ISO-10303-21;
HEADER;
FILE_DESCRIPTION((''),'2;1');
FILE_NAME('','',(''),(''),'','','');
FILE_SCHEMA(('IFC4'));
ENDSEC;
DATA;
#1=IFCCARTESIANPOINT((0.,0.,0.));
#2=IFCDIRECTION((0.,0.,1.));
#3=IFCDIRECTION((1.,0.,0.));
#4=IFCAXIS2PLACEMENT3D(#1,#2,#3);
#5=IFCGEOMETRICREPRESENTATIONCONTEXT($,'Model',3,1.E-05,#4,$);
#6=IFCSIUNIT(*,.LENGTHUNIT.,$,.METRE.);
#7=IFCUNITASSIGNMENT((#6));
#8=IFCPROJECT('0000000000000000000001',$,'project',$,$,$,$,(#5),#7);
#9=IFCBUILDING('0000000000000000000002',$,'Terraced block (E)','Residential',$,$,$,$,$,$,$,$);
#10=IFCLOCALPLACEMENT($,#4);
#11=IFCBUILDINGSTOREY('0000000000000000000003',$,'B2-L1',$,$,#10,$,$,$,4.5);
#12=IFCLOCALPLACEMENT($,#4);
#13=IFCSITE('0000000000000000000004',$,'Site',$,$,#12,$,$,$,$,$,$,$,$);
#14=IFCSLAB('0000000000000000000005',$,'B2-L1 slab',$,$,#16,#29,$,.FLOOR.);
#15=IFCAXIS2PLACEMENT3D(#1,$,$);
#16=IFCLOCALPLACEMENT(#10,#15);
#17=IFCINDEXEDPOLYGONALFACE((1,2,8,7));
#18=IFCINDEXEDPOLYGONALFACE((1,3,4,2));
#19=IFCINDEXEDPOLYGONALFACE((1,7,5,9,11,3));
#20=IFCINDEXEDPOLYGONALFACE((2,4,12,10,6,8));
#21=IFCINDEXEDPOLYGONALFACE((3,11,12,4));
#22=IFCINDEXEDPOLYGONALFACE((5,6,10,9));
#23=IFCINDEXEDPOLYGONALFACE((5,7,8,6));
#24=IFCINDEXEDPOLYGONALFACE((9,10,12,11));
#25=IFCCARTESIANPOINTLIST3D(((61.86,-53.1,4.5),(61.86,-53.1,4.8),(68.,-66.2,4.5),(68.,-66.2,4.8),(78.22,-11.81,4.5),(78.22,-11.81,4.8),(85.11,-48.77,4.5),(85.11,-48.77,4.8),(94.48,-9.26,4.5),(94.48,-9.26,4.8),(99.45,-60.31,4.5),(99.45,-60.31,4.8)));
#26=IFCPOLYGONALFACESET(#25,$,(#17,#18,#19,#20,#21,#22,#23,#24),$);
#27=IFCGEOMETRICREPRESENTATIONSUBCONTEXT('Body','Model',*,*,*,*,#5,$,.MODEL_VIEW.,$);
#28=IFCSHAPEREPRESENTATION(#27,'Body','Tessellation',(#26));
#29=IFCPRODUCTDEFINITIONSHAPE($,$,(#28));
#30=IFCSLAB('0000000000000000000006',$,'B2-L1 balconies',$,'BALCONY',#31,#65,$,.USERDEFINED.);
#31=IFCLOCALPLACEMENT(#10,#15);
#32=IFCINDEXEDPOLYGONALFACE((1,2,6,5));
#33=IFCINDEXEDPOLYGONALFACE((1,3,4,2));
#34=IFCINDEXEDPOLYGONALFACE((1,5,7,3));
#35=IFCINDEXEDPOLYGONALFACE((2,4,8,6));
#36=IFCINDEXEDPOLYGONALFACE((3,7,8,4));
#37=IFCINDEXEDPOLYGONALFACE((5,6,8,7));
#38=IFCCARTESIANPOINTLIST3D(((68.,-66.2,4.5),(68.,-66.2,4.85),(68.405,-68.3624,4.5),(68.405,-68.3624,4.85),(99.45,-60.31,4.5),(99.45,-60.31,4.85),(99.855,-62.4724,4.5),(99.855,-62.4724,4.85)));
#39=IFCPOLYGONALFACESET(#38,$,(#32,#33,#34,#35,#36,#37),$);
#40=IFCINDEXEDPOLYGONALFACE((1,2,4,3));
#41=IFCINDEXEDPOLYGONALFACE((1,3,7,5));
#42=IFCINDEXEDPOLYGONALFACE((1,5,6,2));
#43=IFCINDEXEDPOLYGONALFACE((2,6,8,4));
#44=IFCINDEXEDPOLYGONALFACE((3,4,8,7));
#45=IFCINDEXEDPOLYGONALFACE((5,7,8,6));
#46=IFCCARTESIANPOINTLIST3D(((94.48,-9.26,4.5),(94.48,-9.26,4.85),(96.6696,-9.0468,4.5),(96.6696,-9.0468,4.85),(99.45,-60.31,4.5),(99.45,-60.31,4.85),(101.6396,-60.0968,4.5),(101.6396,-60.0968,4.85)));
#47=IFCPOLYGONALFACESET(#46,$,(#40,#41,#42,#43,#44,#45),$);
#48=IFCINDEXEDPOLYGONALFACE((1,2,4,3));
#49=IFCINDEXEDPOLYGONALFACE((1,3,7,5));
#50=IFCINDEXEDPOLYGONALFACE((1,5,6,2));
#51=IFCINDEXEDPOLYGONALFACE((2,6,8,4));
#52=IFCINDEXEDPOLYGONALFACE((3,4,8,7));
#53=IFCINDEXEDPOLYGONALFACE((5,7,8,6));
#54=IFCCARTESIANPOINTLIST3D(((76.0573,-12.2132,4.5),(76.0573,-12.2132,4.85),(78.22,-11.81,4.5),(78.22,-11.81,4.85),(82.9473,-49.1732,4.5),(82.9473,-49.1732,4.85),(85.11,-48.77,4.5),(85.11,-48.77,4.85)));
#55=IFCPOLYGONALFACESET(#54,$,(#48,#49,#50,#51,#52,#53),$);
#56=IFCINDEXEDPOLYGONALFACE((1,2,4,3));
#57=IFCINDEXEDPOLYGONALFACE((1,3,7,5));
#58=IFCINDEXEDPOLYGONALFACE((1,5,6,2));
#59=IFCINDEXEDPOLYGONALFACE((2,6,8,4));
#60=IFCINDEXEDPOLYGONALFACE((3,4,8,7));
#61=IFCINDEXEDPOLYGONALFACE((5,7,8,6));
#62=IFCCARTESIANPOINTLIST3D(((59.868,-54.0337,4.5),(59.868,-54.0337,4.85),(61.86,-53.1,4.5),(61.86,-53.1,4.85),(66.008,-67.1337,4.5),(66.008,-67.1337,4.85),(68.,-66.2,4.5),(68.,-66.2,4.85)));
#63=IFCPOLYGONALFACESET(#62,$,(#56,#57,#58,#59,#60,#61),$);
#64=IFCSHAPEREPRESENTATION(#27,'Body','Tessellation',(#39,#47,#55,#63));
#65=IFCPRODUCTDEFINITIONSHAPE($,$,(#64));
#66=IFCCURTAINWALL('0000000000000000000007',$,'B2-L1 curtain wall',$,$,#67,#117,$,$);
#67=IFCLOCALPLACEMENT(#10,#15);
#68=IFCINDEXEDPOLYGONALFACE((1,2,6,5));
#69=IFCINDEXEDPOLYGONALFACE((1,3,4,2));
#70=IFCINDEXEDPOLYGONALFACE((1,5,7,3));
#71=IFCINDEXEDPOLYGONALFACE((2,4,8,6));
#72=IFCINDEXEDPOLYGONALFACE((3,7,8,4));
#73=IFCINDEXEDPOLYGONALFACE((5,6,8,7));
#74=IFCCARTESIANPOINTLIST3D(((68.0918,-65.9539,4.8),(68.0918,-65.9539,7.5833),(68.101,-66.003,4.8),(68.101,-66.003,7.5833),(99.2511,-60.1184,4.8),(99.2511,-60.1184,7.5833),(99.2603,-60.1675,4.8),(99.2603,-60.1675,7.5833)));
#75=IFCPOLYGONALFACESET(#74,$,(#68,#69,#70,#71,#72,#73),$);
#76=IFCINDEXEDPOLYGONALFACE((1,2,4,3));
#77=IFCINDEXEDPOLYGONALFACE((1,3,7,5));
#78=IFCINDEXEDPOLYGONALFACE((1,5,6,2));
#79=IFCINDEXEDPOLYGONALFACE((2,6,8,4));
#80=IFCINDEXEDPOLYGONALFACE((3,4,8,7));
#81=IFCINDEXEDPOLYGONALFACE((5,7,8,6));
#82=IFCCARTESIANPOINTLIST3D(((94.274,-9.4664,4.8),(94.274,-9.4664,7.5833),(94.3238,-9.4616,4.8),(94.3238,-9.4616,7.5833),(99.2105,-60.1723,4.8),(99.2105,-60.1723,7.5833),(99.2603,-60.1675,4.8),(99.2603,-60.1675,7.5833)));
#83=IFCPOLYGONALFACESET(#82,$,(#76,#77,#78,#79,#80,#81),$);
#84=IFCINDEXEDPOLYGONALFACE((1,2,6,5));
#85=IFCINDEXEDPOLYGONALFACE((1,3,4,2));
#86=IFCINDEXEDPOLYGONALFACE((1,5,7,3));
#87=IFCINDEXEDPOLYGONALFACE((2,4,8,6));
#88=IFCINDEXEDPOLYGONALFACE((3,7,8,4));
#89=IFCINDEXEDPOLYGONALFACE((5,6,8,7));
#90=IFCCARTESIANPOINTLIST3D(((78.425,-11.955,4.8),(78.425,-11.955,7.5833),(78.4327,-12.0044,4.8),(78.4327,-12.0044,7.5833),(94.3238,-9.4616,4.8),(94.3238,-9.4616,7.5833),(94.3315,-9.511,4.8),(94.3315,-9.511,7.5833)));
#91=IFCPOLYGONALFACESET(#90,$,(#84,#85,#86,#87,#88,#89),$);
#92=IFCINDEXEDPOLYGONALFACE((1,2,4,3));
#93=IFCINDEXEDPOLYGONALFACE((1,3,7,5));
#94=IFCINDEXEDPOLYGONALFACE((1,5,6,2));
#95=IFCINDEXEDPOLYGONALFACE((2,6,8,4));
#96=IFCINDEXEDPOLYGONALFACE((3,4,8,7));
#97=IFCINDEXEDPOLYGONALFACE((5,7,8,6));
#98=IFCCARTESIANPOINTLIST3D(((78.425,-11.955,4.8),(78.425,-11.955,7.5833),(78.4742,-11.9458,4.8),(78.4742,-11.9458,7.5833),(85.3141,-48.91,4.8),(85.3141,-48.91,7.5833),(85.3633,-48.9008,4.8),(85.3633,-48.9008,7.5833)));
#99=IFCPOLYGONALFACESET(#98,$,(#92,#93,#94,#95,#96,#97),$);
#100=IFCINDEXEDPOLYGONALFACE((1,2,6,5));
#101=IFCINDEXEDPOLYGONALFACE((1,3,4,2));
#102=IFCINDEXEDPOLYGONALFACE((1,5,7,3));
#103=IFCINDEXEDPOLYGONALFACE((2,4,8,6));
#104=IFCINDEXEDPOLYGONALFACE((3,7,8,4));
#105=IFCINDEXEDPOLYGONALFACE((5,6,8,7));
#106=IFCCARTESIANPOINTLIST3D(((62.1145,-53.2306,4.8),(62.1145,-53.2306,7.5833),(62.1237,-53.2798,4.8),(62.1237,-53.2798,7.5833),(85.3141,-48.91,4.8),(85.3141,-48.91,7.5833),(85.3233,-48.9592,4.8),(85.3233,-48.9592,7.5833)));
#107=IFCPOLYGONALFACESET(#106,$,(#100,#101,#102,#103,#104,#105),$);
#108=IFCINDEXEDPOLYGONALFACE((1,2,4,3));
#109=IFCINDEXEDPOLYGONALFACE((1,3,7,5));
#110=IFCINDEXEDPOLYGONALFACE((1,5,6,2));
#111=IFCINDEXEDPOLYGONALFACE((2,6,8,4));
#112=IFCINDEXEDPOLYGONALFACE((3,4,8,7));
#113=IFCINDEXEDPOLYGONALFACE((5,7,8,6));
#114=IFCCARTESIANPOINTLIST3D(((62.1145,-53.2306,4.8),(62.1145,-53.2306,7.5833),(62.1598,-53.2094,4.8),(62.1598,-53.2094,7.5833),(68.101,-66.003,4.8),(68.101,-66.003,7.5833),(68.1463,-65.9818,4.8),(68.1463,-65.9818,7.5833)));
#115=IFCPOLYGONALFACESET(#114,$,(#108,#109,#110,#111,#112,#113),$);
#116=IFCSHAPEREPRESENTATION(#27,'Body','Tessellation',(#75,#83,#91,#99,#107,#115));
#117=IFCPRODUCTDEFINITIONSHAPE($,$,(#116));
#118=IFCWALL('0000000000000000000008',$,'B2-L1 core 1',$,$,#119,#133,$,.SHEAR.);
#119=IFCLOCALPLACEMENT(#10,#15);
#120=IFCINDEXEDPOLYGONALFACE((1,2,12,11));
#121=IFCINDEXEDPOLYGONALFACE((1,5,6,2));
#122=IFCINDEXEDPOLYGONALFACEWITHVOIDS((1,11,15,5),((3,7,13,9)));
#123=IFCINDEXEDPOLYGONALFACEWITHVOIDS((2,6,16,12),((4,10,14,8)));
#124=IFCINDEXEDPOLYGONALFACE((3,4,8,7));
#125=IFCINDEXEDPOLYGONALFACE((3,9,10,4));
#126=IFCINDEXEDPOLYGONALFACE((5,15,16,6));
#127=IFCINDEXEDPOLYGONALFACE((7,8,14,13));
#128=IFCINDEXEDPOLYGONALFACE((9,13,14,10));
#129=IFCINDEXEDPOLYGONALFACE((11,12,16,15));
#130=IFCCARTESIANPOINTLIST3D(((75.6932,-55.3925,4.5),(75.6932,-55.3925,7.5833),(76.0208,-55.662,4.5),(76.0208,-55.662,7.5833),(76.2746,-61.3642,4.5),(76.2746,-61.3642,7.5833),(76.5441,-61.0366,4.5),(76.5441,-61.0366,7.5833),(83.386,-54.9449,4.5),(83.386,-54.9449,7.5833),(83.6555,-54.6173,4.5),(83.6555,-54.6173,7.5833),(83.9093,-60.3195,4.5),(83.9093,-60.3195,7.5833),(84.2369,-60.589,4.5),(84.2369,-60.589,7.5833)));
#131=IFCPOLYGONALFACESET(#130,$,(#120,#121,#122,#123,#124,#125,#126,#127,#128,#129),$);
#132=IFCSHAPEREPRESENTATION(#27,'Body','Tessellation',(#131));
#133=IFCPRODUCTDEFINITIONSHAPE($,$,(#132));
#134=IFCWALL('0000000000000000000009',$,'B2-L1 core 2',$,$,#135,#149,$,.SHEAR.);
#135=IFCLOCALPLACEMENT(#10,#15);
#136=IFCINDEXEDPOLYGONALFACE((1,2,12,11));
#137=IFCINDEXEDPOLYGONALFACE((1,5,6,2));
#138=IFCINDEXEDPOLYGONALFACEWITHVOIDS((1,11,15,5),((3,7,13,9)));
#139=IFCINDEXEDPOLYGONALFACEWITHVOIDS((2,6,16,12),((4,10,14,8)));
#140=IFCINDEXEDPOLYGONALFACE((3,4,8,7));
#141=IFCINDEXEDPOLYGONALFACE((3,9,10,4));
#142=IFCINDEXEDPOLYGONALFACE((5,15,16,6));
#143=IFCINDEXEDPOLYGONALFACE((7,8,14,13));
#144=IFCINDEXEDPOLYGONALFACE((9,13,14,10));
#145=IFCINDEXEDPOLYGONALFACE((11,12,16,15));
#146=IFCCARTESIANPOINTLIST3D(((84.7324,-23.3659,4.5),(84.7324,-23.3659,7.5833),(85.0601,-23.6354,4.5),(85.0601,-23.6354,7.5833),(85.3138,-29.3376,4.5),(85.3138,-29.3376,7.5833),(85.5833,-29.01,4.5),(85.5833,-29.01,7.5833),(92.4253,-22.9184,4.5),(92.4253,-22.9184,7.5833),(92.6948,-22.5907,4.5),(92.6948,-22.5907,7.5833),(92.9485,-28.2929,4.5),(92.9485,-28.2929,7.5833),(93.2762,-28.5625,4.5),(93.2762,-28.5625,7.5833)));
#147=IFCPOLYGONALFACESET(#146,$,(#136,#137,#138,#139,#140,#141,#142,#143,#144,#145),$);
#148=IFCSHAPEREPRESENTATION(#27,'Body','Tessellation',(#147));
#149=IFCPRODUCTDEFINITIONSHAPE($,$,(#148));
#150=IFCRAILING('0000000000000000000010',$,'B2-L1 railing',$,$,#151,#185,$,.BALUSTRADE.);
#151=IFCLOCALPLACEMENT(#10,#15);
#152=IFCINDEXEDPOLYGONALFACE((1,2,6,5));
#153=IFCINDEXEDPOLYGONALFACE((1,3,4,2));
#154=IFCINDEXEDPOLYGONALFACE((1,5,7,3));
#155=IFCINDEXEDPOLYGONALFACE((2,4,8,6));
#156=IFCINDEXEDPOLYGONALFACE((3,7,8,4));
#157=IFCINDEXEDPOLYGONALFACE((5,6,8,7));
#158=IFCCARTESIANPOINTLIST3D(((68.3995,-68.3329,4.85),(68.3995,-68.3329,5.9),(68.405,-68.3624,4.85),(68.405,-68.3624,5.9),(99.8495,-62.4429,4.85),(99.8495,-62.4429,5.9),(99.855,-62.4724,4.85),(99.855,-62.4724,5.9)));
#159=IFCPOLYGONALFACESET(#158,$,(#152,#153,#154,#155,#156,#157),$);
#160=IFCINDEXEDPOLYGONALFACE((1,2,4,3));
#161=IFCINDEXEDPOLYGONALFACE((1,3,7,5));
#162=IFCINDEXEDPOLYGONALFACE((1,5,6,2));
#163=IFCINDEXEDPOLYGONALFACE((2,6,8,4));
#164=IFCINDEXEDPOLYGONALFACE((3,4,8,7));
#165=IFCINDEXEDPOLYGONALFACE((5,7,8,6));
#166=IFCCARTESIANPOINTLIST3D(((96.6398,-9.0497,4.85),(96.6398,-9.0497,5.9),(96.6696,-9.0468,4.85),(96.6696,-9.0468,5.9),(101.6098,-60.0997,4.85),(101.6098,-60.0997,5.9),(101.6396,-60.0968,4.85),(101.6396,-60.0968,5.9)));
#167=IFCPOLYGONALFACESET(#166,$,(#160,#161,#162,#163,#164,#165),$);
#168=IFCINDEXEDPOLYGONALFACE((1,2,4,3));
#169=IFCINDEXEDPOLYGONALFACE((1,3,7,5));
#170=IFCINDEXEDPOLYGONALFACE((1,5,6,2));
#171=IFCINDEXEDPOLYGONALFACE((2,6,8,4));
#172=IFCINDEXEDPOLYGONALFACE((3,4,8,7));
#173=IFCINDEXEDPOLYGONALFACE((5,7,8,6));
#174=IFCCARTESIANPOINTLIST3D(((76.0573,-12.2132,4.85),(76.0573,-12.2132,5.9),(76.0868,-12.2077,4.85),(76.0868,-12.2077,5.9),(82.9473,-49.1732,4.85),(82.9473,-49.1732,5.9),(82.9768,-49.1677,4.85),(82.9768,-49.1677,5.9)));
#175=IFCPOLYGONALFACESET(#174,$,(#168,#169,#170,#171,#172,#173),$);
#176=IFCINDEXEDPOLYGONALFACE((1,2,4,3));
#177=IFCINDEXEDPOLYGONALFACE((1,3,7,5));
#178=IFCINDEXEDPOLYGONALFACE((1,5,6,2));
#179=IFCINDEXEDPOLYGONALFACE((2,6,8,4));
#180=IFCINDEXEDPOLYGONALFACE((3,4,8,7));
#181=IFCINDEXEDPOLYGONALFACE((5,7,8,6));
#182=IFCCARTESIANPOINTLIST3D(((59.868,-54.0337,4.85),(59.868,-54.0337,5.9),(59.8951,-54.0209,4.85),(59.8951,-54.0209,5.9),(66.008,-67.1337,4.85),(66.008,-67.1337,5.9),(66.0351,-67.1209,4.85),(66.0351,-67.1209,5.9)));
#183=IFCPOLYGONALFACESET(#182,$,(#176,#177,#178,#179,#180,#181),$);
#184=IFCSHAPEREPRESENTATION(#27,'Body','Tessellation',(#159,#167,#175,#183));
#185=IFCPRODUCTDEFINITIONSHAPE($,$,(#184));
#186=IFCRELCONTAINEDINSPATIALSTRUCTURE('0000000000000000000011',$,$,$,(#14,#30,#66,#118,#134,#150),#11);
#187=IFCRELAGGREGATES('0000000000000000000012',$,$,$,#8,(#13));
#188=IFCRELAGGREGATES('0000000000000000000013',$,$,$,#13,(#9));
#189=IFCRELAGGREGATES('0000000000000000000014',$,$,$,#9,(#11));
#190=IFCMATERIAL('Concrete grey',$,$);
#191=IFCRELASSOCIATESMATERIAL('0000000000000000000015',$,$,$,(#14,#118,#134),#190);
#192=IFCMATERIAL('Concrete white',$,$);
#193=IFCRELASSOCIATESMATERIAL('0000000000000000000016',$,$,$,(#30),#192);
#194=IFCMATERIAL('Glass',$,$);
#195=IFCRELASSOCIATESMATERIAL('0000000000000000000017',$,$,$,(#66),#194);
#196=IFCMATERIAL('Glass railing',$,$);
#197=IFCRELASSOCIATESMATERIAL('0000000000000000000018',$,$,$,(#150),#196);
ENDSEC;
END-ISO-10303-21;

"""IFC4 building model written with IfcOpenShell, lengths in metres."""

from ifc_helpers import new_model, si_unit, frame, origin_with_axes, place, context, subcontext, project, spatial, polyline, outline, extrude, material, element, save


model = new_model("IFC4")

# Units and contexts
model_context = context("Model", 3, precision=1e-05, world=origin_with_axes())
body_context = subcontext(model_context, "Body", "Model", "MODEL_VIEW")
ifc_project = project(units=[si_unit("LENGTHUNIT", "METRE")], contexts=[model_context])

# Site, building, storey
site_placement = place(None, origin_with_axes())
site = spatial("IfcSite", under=ifc_project, at=site_placement, Name="Site")
building = spatial("IfcBuilding", under=site, Name="Terraced block (E)", Description="Residential")
storey_placement = place(None, origin_with_axes())
storey = spatial("IfcBuildingStorey", under=building, at=storey_placement, Name="B2-L1", Elevation=4.5)

# Slabs
ifc_material_1 = material(Name="Concrete grey")
slab_1_placement = place(storey_placement, origin_with_axes())
element("IfcSlab", 1, at=slab_1_placement, inside=storey, material=ifc_material_1, Name="B2-L1 slab", PredefinedType="FLOOR", context=body_context, shape_type="SweptSolid", body=[
    extrude(outline(polyline([(68.0, -66.2), (99.45, -60.31), (94.48, -9.26), (78.22, -11.81), (85.11, -48.77), (61.86, -53.1), (68.0, -66.2)])), frame((0.0, 0.0, 4.5), z_axis=(0.0, 0.0, 1.0), x_axis=(1.0, 0.0, 0.0)), (0.0, 0.0, 1.0), 0.3),
])
ifc_material_2 = material(Name="Concrete white")
slab_2_placement = place(storey_placement, origin_with_axes())
element("IfcSlab", 2, at=slab_2_placement, inside=storey, material=ifc_material_2, Name="B2-L1 balconies", ObjectType="BALCONY", PredefinedType="USERDEFINED", context=body_context, shape_type="SweptSolid", body=[
    extrude(outline(polyline([(68.0, -66.2), (99.45, -60.31), (99.855, -62.4724), (68.405, -68.3624), (68.0, -66.2)])), frame((0.0, 0.0, 4.5), z_axis=(0.0, 0.0, 1.0), x_axis=(1.0, 0.0, 0.0)), (0.0, 0.0, 1.0), 0.35),
    extrude(outline(polyline([(99.45, -60.31), (94.48, -9.26), (96.6696, -9.0468), (101.6396, -60.0968), (99.45, -60.31)])), frame((0.0, 0.0, 4.5), z_axis=(0.0, 0.0, 1.0), x_axis=(1.0, 0.0, 0.0)), (0.0, 0.0, 1.0), 0.35),
    extrude(outline(polyline([(78.22, -11.81), (85.11, -48.77), (82.9473, -49.1732), (76.0573, -12.2132), (78.22, -11.81)])), frame((0.0, 0.0, 4.5), z_axis=(0.0, 0.0, 1.0), x_axis=(1.0, 0.0, 0.0)), (0.0, 0.0, 1.0), 0.35),
    extrude(outline(polyline([(61.86, -53.1), (68.0, -66.2), (66.008, -67.1337), (59.868, -54.0337), (61.86, -53.1)])), frame((0.0, 0.0, 4.5), z_axis=(0.0, 0.0, 1.0), x_axis=(1.0, 0.0, 0.0)), (0.0, 0.0, 1.0), 0.35),
])

# Curtain wall
ifc_material_3 = material(Name="Glass")
curtain_wall_placement = place(storey_placement, origin_with_axes())
element("IfcCurtainWall", 3, at=curtain_wall_placement, inside=storey, material=ifc_material_3, Name="B2-L1 curtain wall", context=body_context, shape_type="SweptSolid", body=[
    extrude(outline(polyline([(68.101, -66.003), (99.2603, -60.1675), (99.2511, -60.1184), (68.0918, -65.9539), (68.101, -66.003)])), frame((0.0, 0.0, 4.8), z_axis=(0.0, 0.0, 1.0), x_axis=(1.0, 0.0, 0.0)), (0.0, 0.0, 1.0), 2.7833),
    extrude(outline(polyline([(99.2603, -60.1675), (94.3238, -9.4616), (94.274, -9.4664), (99.2105, -60.1723), (99.2603, -60.1675)])), frame((0.0, 0.0, 4.8), z_axis=(0.0, 0.0, 1.0), x_axis=(1.0, 0.0, 0.0)), (0.0, 0.0, 1.0), 2.7833),
    extrude(outline(polyline([(94.3238, -9.4616), (78.425, -11.955), (78.4327, -12.0044), (94.3315, -9.511), (94.3238, -9.4616)])), frame((0.0, 0.0, 4.8), z_axis=(0.0, 0.0, 1.0), x_axis=(1.0, 0.0, 0.0)), (0.0, 0.0, 1.0), 2.7833),
    extrude(outline(polyline([(78.425, -11.955), (85.3141, -48.91), (85.3633, -48.9008), (78.4742, -11.9458), (78.425, -11.955)])), frame((0.0, 0.0, 4.8), z_axis=(0.0, 0.0, 1.0), x_axis=(1.0, 0.0, 0.0)), (0.0, 0.0, 1.0), 2.7833),
    extrude(outline(polyline([(85.3141, -48.91), (62.1145, -53.2306), (62.1237, -53.2798), (85.3233, -48.9592), (85.3141, -48.91)])), frame((0.0, 0.0, 4.8), z_axis=(0.0, 0.0, 1.0), x_axis=(1.0, 0.0, 0.0)), (0.0, 0.0, 1.0), 2.7833),
    extrude(outline(polyline([(62.1145, -53.2306), (68.101, -66.003), (68.1463, -65.9818), (62.1598, -53.2094), (62.1145, -53.2306)])), frame((0.0, 0.0, 4.8), z_axis=(0.0, 0.0, 1.0), x_axis=(1.0, 0.0, 0.0)), (0.0, 0.0, 1.0), 2.7833),
])

# Walls
wall_1_placement = place(storey_placement, origin_with_axes())
element("IfcWall", 4, at=wall_1_placement, inside=storey, material=ifc_material_1, Name="B2-L1 core 1", PredefinedType="SHEAR", context=body_context, shape_type="SweptSolid", body=[
    extrude(outline(polyline([(84.2369, -60.589), (83.6555, -54.6173), (75.6932, -55.3925), (76.2746, -61.3642), (84.2369, -60.589)]), holes=[polyline([(83.9093, -60.3195), (83.386, -54.9449), (76.0208, -55.662), (76.5441, -61.0366), (83.9093, -60.3195)])]), frame((0.0, 0.0, 4.5), z_axis=(0.0, 0.0, 1.0), x_axis=(1.0, 0.0, 0.0)), (0.0, 0.0, 1.0), 3.0833),
])
wall_2_placement = place(storey_placement, origin_with_axes())
element("IfcWall", 5, at=wall_2_placement, inside=storey, material=ifc_material_1, Name="B2-L1 core 2", PredefinedType="SHEAR", context=body_context, shape_type="SweptSolid", body=[
    extrude(outline(polyline([(93.2762, -28.5625), (92.6948, -22.5907), (84.7324, -23.3659), (85.3138, -29.3376), (93.2762, -28.5625)]), holes=[polyline([(92.9485, -28.2929), (92.4253, -22.9184), (85.0601, -23.6354), (85.5833, -29.01), (92.9485, -28.2929)])]), frame((0.0, 0.0, 4.5), z_axis=(0.0, 0.0, 1.0), x_axis=(1.0, 0.0, 0.0)), (0.0, 0.0, 1.0), 3.0833),
])

# Railing
ifc_material_4 = material(Name="Glass railing")
railing_placement = place(storey_placement, origin_with_axes())
element("IfcRailing", 6, at=railing_placement, inside=storey, material=ifc_material_4, Name="B2-L1 railing", PredefinedType="BALUSTRADE", context=body_context, shape_type="SweptSolid", body=[
    extrude(outline(polyline([(68.405, -68.3624), (99.855, -62.4724), (99.8495, -62.4429), (68.3995, -68.3329), (68.405, -68.3624)])), frame((0.0, 0.0, 4.85), z_axis=(0.0, 0.0, 1.0), x_axis=(1.0, 0.0, 0.0)), (0.0, 0.0, 1.0), 1.05),
    extrude(outline(polyline([(101.6396, -60.0968), (96.6696, -9.0468), (96.6398, -9.0497), (101.6098, -60.0997), (101.6396, -60.0968)])), frame((0.0, 0.0, 4.85), z_axis=(0.0, 0.0, 1.0), x_axis=(1.0, 0.0, 0.0)), (0.0, 0.0, 1.0), 1.05),
    extrude(outline(polyline([(76.0573, -12.2132), (82.9473, -49.1732), (82.9768, -49.1677), (76.0868, -12.2077), (76.0573, -12.2132)])), frame((0.0, 0.0, 4.85), z_axis=(0.0, 0.0, 1.0), x_axis=(1.0, 0.0, 0.0)), (0.0, 0.0, 1.0), 1.05),
    extrude(outline(polyline([(59.868, -54.0337), (66.008, -67.1337), (66.0351, -67.1209), (59.8951, -54.0209), (59.868, -54.0337)])), frame((0.0, 0.0, 4.85), z_axis=(0.0, 0.0, 1.0), x_axis=(1.0, 0.0, 0.0)), (0.0, 0.0, 1.0), 1.05),
])

save(model, "model.ifc")
